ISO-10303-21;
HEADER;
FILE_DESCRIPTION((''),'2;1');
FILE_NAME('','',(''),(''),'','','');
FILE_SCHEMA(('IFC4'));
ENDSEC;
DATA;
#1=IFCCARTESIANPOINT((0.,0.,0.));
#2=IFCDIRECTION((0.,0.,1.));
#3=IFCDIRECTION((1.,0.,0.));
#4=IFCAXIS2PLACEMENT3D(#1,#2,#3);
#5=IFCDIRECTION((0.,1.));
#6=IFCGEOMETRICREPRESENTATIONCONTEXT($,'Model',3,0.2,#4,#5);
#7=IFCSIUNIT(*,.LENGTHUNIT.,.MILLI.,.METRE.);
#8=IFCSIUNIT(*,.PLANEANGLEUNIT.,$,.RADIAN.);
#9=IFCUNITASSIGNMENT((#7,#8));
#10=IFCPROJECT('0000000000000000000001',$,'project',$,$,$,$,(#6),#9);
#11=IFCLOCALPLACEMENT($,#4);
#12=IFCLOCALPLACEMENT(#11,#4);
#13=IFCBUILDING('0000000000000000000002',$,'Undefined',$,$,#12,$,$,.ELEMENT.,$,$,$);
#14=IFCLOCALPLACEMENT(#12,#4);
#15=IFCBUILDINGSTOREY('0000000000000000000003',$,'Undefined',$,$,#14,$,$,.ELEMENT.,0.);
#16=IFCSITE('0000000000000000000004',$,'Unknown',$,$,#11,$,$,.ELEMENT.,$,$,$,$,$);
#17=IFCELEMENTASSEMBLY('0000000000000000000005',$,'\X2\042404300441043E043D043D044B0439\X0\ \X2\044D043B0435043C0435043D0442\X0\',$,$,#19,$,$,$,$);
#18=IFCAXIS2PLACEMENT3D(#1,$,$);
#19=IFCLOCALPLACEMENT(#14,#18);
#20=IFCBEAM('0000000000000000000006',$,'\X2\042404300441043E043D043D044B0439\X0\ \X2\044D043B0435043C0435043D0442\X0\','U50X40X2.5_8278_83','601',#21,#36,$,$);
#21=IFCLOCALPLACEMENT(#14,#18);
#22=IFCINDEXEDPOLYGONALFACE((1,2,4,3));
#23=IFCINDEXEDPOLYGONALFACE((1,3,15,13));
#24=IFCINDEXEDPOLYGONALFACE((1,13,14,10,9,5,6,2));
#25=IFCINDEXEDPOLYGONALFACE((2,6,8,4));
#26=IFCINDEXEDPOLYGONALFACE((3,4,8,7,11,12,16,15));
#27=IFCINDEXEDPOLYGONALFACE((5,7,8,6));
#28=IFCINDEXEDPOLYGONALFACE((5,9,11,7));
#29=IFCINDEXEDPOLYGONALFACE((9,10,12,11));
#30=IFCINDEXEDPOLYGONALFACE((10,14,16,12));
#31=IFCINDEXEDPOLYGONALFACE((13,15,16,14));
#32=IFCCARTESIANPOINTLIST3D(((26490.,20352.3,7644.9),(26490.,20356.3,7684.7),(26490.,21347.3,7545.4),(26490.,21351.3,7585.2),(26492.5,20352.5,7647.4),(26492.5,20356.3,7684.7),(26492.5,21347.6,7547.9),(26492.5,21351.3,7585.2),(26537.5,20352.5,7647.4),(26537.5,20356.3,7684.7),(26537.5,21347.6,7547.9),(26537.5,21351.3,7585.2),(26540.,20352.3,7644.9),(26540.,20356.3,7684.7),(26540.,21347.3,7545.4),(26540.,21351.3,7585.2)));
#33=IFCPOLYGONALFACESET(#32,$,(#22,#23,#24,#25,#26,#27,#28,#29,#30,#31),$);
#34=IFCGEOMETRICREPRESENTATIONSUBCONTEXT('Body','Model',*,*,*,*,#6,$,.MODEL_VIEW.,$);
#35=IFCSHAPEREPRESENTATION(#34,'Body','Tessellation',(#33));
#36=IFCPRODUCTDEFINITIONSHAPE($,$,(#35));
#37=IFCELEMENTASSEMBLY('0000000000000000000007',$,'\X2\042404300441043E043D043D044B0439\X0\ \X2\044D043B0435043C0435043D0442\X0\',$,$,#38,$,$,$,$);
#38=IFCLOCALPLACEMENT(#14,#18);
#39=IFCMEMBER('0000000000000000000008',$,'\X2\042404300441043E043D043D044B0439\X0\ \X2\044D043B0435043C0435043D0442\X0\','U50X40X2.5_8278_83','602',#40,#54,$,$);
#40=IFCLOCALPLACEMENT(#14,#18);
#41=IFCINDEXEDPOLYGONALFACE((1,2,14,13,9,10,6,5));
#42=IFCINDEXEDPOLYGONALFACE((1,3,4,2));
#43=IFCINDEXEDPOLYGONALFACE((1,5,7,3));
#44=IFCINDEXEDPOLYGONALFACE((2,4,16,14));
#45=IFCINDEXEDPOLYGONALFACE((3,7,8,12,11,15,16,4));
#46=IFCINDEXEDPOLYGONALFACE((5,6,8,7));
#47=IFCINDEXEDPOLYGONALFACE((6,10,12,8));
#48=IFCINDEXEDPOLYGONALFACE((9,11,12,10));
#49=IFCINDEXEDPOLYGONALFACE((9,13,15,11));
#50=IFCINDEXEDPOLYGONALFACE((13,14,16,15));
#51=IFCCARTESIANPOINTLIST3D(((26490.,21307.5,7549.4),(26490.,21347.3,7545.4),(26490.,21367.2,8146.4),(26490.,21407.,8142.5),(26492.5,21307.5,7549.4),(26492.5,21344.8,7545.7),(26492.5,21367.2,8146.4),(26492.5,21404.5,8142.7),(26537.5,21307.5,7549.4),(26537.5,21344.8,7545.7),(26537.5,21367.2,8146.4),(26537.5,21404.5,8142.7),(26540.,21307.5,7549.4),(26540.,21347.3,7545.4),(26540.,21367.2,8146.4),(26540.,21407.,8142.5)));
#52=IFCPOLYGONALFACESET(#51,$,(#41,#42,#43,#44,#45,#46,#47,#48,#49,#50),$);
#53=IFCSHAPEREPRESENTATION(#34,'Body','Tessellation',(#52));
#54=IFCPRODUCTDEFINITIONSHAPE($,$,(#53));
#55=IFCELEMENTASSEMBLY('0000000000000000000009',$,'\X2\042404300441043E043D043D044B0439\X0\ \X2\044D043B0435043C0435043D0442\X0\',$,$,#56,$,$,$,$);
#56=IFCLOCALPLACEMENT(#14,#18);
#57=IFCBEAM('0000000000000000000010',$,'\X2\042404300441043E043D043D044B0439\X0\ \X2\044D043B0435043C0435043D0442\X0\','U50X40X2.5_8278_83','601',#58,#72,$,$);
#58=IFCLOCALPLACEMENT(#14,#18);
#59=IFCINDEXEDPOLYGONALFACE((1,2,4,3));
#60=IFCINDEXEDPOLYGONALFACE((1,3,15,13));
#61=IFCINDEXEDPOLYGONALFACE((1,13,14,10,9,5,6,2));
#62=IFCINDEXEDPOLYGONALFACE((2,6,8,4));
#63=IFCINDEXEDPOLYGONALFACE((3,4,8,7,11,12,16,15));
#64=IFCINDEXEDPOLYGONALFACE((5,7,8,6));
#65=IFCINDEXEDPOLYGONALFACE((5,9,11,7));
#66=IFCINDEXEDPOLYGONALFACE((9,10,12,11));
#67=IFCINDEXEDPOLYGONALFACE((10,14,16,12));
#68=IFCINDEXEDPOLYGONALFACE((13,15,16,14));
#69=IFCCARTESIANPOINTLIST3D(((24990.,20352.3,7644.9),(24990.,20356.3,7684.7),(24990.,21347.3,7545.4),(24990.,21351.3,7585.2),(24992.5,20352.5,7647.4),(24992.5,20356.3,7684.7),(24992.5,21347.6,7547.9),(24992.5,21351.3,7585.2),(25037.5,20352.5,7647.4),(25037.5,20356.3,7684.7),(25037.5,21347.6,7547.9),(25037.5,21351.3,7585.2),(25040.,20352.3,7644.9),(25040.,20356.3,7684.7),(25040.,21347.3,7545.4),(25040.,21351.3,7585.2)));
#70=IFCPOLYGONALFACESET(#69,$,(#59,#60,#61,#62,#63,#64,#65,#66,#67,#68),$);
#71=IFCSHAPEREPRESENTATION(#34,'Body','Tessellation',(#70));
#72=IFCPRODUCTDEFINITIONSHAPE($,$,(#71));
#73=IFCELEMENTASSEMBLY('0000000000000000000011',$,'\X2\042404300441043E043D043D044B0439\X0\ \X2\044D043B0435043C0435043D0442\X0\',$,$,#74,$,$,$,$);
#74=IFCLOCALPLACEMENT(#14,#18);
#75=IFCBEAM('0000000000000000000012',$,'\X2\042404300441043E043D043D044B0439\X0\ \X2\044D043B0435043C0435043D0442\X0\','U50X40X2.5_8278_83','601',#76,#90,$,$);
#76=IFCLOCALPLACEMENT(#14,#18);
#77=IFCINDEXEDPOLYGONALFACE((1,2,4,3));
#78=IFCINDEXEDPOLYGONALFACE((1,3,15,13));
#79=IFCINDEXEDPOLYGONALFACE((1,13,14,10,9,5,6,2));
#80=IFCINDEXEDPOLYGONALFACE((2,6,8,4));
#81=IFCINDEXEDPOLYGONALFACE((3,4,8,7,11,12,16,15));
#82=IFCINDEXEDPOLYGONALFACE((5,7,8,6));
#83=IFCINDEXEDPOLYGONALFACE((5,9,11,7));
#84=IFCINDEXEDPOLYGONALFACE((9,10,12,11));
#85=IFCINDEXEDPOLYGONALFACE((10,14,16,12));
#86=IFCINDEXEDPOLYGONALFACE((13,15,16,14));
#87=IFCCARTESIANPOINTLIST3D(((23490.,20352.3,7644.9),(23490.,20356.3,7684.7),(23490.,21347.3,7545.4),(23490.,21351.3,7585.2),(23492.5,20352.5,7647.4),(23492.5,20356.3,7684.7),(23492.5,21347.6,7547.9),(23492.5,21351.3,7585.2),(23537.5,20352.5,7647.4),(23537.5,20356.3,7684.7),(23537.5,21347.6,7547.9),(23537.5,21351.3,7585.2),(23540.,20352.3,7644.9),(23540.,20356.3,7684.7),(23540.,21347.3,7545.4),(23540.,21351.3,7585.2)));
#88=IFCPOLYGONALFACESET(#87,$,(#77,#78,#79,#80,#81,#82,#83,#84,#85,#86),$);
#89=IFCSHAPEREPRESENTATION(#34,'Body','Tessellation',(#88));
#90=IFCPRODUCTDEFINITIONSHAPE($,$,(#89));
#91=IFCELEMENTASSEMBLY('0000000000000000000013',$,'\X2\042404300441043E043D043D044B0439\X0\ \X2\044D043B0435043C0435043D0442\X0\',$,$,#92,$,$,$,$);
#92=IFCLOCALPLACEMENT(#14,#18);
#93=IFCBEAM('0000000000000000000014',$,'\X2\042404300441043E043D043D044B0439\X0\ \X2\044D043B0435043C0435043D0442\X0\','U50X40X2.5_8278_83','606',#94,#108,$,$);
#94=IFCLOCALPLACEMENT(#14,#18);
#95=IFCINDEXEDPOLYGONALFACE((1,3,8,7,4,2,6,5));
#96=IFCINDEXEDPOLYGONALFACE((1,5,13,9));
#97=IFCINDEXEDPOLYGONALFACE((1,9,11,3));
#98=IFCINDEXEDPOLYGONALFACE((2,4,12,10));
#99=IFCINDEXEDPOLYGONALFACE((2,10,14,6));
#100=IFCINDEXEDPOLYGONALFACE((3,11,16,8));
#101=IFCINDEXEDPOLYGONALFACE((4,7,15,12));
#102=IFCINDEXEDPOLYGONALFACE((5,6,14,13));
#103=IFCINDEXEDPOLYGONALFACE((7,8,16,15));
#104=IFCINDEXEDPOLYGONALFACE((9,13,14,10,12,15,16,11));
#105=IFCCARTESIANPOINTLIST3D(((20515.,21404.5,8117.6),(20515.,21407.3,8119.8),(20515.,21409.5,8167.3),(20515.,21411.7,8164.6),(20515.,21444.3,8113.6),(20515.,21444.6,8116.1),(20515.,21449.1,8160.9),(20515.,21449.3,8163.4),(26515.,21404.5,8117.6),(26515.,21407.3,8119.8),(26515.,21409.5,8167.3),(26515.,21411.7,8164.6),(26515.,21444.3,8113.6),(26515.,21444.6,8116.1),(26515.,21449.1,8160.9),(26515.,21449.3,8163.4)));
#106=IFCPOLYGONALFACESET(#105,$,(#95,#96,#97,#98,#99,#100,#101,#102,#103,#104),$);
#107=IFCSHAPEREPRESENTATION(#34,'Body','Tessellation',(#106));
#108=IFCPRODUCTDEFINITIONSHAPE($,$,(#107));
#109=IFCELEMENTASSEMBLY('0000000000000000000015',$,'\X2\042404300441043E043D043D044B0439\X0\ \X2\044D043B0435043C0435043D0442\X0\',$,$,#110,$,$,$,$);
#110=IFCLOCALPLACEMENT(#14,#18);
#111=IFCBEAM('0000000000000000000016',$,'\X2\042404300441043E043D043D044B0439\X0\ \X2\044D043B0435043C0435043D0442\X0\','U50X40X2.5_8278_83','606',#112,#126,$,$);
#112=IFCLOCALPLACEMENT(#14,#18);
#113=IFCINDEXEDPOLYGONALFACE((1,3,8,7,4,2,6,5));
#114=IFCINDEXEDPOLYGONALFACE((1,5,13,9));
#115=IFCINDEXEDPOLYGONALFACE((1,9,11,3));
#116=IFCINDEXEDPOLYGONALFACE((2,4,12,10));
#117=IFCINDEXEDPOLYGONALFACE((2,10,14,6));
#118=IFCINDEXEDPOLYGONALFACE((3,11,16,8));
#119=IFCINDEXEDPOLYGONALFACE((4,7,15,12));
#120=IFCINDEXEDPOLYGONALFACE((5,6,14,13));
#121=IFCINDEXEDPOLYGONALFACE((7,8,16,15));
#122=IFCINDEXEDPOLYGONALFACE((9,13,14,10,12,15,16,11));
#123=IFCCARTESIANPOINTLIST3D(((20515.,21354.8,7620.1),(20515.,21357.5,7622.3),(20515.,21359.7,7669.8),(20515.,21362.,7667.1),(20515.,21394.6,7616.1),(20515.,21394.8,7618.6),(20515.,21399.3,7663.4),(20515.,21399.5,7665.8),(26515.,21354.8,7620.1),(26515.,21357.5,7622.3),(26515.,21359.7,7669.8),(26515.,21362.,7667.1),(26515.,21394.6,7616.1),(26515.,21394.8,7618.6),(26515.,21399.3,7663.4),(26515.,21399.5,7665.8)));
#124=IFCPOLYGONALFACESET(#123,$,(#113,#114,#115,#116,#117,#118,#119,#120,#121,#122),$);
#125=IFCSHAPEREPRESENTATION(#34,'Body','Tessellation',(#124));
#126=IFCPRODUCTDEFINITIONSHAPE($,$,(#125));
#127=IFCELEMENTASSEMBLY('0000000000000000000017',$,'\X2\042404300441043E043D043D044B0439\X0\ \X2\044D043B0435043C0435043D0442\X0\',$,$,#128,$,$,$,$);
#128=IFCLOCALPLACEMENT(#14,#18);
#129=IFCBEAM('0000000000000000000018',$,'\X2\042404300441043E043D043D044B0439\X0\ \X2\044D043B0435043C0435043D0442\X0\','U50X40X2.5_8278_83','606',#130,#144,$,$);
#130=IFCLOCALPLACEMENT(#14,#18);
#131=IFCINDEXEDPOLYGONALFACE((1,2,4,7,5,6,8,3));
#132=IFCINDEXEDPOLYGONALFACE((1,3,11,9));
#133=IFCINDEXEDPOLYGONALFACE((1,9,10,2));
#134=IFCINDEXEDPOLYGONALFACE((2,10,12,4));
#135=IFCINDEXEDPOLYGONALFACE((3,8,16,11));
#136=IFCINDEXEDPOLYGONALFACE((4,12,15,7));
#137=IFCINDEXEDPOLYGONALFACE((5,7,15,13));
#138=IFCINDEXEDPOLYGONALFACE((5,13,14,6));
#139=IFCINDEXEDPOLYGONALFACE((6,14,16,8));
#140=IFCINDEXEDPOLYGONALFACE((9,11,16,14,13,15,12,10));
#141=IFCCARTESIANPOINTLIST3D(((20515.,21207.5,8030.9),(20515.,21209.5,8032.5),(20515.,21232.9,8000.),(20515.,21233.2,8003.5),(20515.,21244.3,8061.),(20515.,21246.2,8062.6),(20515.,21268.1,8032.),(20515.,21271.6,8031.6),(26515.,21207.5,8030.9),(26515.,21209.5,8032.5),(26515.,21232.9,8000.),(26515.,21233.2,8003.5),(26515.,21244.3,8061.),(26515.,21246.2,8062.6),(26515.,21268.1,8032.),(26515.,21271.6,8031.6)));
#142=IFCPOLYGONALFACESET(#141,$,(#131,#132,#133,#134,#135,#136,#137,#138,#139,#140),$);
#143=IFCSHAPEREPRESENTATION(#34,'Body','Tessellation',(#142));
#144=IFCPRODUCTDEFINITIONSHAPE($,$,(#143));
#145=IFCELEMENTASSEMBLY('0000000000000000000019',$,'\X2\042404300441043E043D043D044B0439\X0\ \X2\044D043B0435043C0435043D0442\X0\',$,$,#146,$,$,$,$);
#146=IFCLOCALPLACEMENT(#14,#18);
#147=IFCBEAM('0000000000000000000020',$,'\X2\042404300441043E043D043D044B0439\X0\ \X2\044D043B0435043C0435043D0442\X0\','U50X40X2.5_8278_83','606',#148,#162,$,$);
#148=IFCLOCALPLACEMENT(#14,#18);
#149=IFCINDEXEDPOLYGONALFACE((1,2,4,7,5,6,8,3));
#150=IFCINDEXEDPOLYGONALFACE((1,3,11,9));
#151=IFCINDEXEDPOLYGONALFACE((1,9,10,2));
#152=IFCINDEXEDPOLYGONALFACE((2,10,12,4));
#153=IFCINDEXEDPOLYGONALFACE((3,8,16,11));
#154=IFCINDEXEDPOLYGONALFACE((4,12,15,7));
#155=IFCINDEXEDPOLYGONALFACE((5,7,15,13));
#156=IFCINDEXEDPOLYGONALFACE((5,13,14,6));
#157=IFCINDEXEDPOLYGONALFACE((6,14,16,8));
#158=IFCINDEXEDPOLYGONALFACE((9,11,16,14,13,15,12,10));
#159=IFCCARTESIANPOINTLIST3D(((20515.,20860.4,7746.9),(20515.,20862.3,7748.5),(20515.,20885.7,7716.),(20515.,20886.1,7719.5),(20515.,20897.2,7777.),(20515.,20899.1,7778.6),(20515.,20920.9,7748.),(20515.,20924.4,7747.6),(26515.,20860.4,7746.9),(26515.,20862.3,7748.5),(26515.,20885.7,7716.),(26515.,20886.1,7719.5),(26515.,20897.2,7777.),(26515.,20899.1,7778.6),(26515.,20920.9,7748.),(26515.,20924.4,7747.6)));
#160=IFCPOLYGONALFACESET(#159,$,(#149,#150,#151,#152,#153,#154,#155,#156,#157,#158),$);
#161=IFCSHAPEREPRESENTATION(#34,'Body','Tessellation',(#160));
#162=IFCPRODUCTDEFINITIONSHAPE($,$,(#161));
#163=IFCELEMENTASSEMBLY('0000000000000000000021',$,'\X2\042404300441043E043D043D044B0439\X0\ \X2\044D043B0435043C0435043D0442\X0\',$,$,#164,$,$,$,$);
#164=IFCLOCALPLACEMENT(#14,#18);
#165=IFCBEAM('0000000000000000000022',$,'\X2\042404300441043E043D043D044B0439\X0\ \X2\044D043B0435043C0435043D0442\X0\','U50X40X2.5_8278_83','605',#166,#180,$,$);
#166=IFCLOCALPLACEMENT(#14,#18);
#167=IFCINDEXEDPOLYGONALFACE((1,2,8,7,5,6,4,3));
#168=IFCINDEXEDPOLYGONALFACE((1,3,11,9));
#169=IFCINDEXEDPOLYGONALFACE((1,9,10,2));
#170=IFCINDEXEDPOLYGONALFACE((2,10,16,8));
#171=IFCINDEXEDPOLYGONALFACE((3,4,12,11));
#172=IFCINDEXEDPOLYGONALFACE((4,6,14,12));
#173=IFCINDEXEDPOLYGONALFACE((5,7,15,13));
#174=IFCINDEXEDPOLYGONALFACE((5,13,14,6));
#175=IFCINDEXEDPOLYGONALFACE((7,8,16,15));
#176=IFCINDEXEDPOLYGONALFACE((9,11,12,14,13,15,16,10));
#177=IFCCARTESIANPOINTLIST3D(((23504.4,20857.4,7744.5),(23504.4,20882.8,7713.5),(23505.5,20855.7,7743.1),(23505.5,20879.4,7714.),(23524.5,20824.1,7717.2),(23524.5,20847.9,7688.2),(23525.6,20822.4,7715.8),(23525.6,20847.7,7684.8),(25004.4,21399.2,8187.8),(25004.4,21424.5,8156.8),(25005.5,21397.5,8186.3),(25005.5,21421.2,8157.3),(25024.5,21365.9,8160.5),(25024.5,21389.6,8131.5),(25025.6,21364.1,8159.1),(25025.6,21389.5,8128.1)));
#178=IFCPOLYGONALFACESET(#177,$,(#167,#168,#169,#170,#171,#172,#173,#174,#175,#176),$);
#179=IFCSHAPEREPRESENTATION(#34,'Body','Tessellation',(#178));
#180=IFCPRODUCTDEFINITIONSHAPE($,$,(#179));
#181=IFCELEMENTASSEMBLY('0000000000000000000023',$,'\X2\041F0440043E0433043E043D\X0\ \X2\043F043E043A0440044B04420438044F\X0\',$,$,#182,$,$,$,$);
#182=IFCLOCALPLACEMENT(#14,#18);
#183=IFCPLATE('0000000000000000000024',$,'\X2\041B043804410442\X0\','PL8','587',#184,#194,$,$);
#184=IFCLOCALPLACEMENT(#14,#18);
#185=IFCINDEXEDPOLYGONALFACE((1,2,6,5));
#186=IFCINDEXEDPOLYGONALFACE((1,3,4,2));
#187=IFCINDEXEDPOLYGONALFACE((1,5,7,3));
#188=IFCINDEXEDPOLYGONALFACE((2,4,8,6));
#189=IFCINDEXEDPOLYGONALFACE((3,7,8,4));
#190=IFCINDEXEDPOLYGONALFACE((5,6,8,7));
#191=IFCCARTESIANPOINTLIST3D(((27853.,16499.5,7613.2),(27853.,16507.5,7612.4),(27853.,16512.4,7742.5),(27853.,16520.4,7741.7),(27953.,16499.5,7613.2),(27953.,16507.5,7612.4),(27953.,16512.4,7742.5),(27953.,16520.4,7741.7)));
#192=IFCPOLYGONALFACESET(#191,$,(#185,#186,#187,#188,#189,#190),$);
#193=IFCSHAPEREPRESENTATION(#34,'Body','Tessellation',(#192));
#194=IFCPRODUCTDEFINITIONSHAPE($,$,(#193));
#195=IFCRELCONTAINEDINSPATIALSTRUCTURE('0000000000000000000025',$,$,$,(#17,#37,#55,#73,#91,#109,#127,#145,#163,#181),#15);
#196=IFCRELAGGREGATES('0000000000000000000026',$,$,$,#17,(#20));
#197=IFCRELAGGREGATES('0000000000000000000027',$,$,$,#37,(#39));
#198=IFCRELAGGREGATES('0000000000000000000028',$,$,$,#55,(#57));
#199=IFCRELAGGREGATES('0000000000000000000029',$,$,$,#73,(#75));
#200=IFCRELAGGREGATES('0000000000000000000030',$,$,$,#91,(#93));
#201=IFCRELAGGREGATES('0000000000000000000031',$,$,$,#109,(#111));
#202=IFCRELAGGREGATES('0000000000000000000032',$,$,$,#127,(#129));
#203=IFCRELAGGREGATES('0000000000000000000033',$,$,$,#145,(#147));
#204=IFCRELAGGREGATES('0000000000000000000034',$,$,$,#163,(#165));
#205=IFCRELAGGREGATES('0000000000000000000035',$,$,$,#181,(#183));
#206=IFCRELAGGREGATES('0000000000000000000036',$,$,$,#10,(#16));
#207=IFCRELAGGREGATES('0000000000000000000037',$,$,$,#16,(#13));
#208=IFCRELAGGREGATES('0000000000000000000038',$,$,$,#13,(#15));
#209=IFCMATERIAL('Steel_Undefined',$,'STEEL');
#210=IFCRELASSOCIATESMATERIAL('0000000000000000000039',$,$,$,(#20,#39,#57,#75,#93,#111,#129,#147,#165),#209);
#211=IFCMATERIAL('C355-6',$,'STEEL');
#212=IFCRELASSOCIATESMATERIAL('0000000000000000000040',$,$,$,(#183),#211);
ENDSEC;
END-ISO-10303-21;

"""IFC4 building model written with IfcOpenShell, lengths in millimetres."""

from ifc_helpers import new_model, si_unit, direction, frame, origin_with_axes, place, context, subcontext, project, spatial, line, indexed_curve, outline, extrude, material, element, aggregate, save


model = new_model("IFC4")

# Units and contexts
model_context = context("Model", 3, precision=0.2, world=origin_with_axes(), true_north=direction((0.0, 1.0)))
body_context = subcontext(model_context, "Body", "Model", "MODEL_VIEW")
ifc_project = project(units=[si_unit("LENGTHUNIT", "METRE", prefix="MILLI"), si_unit("PLANEANGLEUNIT", "RADIAN")], contexts=[model_context])

# Site, building, storey
site_placement = place(None, origin_with_axes())
site = spatial("IfcSite", under=ifc_project, at=site_placement, Name="Unknown", CompositionType="ELEMENT")
building_placement = place(site_placement, origin_with_axes())
building = spatial("IfcBuilding", under=site, at=building_placement, Name="Undefined", CompositionType="ELEMENT")
storey_placement = place(building_placement, origin_with_axes())
storey = spatial("IfcBuildingStorey", under=building, at=storey_placement, Name="Undefined", CompositionType="ELEMENT", Elevation=0.0)

# Element assembly, beam
assembly_1_placement = place(storey_placement, frame((26515.0, 21349.3, 7565.3), z_axis=(0.0, 0.099504, 0.995037), x_axis=(0.0, -0.995037, 0.099504)))
assembly_1 = element("IfcElementAssembly", 1, at=assembly_1_placement, inside=storey, Name="Фасонный элемент")
ifc_material_1 = material(Name="Steel_Undefined", Category="STEEL")
beam_1_placement = place(assembly_1_placement, origin_with_axes())
beam_1 = element("IfcBeam", 2, at=beam_1_placement, material=ifc_material_1, Name="Фасонный элемент", Description="U50X40X2.5_8278_83", ObjectType="601", context=body_context, shape_type="SolidModel", body=[
    extrude(outline(indexed_curve([(-20.0, -25.0), (20.0, -25.0), (20.0, -22.5), (-17.5, -22.5), (-17.5, 22.5), (20.0, 22.5), (20.0, 25.0), (-20.0, 25.0)], segments=[line(1, 2, 3, 4, 5, 6, 7, 8, 1)])), frame((0.0, 0.0, 0.0), z_axis=(-1.0, 0.0, 0.0), x_axis=(0.0, 0.0, 1.0)), (0.0, 0.0, -1.0), 1000.0),
])
aggregate(assembly_1, [beam_1])

# Element assembly, member
assembly_2_placement = place(storey_placement, frame((26515.0, 21327.4, 7547.4), z_axis=(0.0, -0.995037, 0.099504), x_axis=(0.0, 0.099504, 0.995037)))
assembly_2 = element("IfcElementAssembly", 3, at=assembly_2_placement, inside=storey, Name="Фасонный элемент")
member_placement = place(assembly_2_placement, origin_with_axes())
member = element("IfcMember", 4, at=member_placement, material=ifc_material_1, Name="Фасонный элемент", Description="U50X40X2.5_8278_83", ObjectType="602", context=body_context, shape_type="SolidModel", body=[
    extrude(outline(indexed_curve([(-20.0, -25.0), (20.0, -25.0), (20.0, -22.5), (-17.5, -22.5), (-17.5, 22.5), (20.0, 22.5), (20.0, 25.0), (-20.0, 25.0)], segments=[line(1, 2, 3, 4, 5, 6, 7, 8, 1)])), frame((0.0, 0.0, 0.0), z_axis=(-1.0, 0.0, 0.0), x_axis=(0.0, 0.0, 1.0)), (0.0, 0.0, -1.0), 600.0),
])
aggregate(assembly_2, [member])

# Element assemblies, beams
assembly_3_placement = place(storey_placement, frame((25015.0, 21349.3, 7565.3), z_axis=(0.0, 0.099504, 0.995037), x_axis=(0.0, -0.995037, 0.099504)))
assembly_3 = element("IfcElementAssembly", 5, at=assembly_3_placement, inside=storey, Name="Фасонный элемент")
beam_2_placement = place(assembly_3_placement, origin_with_axes())
beam_2 = element("IfcBeam", 6, at=beam_2_placement, material=ifc_material_1, Name="Фасонный элемент", Description="U50X40X2.5_8278_83", ObjectType="601", context=body_context, shape_type="SolidModel", body=[
    extrude(outline(indexed_curve([(-20.0, -25.0), (20.0, -25.0), (20.0, -22.5), (-17.5, -22.5), (-17.5, 22.5), (20.0, 22.5), (20.0, 25.0), (-20.0, 25.0)], segments=[line(1, 2, 3, 4, 5, 6, 7, 8, 1)])), frame((0.0, 0.0, 0.0), z_axis=(-1.0, 0.0, 0.0), x_axis=(0.0, 0.0, 1.0)), (0.0, 0.0, -1.0), 1000.0),
])
aggregate(assembly_3, [beam_2])
assembly_4_placement = place(storey_placement, frame((23515.0, 21349.3, 7565.3), z_axis=(0.0, 0.099504, 0.995037), x_axis=(0.0, -0.995037, 0.099504)))
assembly_4 = element("IfcElementAssembly", 7, at=assembly_4_placement, inside=storey, Name="Фасонный элемент")
beam_3_placement = place(assembly_4_placement, origin_with_axes())
beam_3 = element("IfcBeam", 8, at=beam_3_placement, material=ifc_material_1, Name="Фасонный элемент", Description="U50X40X2.5_8278_83", ObjectType="601", context=body_context, shape_type="SolidModel", body=[
    extrude(outline(indexed_curve([(-20.0, -25.0), (20.0, -25.0), (20.0, -22.5), (-17.5, -22.5), (-17.5, 22.5), (20.0, 22.5), (20.0, 25.0), (-20.0, 25.0)], segments=[line(1, 2, 3, 4, 5, 6, 7, 8, 1)])), frame((0.0, 0.0, 0.0), z_axis=(-1.0, 0.0, 0.0), x_axis=(0.0, 0.0, 1.0)), (0.0, 0.0, -1.0), 1000.0),
])
aggregate(assembly_4, [beam_3])
assembly_5_placement = place(storey_placement, frame((26515.0, 21426.9, 8140.5), z_axis=(0.0, 0.995037, -0.099504), x_axis=(-1.0, 0.0, 0.0)))
assembly_5 = element("IfcElementAssembly", 9, at=assembly_5_placement, inside=storey, Name="Фасонный элемент")
beam_4_placement = place(assembly_5_placement, origin_with_axes())
beam_4 = element("IfcBeam", 10, at=beam_4_placement, material=ifc_material_1, Name="Фасонный элемент", Description="U50X40X2.5_8278_83", ObjectType="606", context=body_context, shape_type="SolidModel", body=[
    extrude(outline(indexed_curve([(-20.0, -25.0), (20.0, -25.0), (20.0, -22.5), (-17.5, -22.5), (-17.5, 22.5), (20.0, 22.5), (20.0, 25.0), (-20.0, 25.0)], segments=[line(1, 2, 3, 4, 5, 6, 7, 8, 1)])), frame((0.0, 0.0, 0.0), z_axis=(-1.0, 0.0, 0.0), x_axis=(0.0, 0.0, 1.0)), (0.0, 0.0, -1.0), 6000.0),
])
aggregate(assembly_5, [beam_4])
assembly_6_placement = place(storey_placement, frame((26515.0, 21377.2, 7643.0), z_axis=(0.0, 0.995037, -0.099504), x_axis=(-1.0, 0.0, 0.0)))
assembly_6 = element("IfcElementAssembly", 11, at=assembly_6_placement, inside=storey, Name="Фасонный элемент")
beam_5_placement = place(assembly_6_placement, origin_with_axes())
beam_5 = element("IfcBeam", 12, at=beam_5_placement, material=ifc_material_1, Name="Фасонный элемент", Description="U50X40X2.5_8278_83", ObjectType="606", context=body_context, shape_type="SolidModel", body=[
    extrude(outline(indexed_curve([(-20.0, -25.0), (20.0, -25.0), (20.0, -22.5), (-17.5, -22.5), (-17.5, 22.5), (20.0, 22.5), (20.0, 25.0), (-20.0, 25.0)], segments=[line(1, 2, 3, 4, 5, 6, 7, 8, 1)])), frame((0.0, 0.0, 0.0), z_axis=(-1.0, 0.0, 0.0), x_axis=(0.0, 0.0, 1.0)), (0.0, 0.0, -1.0), 6000.0),
])
aggregate(assembly_6, [beam_5])
assembly_7_placement = place(storey_placement, frame((26515.0, 21239.6, 8031.3), z_axis=(0.0, -0.633238, 0.773957), x_axis=(-1.0, 0.0, 0.0)))
assembly_7 = element("IfcElementAssembly", 13, at=assembly_7_placement, inside=storey, Name="Фасонный элемент")
beam_6_placement = place(assembly_7_placement, origin_with_axes())
beam_6 = element("IfcBeam", 14, at=beam_6_placement, material=ifc_material_1, Name="Фасонный элемент", Description="U50X40X2.5_8278_83", ObjectType="606", context=body_context, shape_type="SolidModel", body=[
    extrude(outline(indexed_curve([(-20.0, -25.0), (20.0, -25.0), (20.0, -22.5), (-17.5, -22.5), (-17.5, 22.5), (20.0, 22.5), (20.0, 25.0), (-20.0, 25.0)], segments=[line(1, 2, 3, 4, 5, 6, 7, 8, 1)])), frame((0.0, 0.0, 0.0), z_axis=(-1.0, 0.0, 0.0), x_axis=(0.0, 0.0, 1.0)), (0.0, 0.0, -1.0), 6000.0),
])
aggregate(assembly_7, [beam_6])
assembly_8_placement = place(storey_placement, frame((26515.0, 20892.4, 7747.3), z_axis=(0.0, -0.633238, 0.773957), x_axis=(-1.0, 0.0, 0.0)))
assembly_8 = element("IfcElementAssembly", 15, at=assembly_8_placement, inside=storey, Name="Фасонный элемент")
beam_7_placement = place(assembly_8_placement, origin_with_axes())
beam_7 = element("IfcBeam", 16, at=beam_7_placement, material=ifc_material_1, Name="Фасонный элемент", Description="U50X40X2.5_8278_83", ObjectType="606", context=body_context, shape_type="SolidModel", body=[
    extrude(outline(indexed_curve([(-20.0, -25.0), (20.0, -25.0), (20.0, -22.5), (-17.5, -22.5), (-17.5, 22.5), (20.0, 22.5), (20.0, 25.0), (-20.0, 25.0)], segments=[line(1, 2, 3, 4, 5, 6, 7, 8, 1)])), frame((0.0, 0.0, 0.0), z_axis=(-1.0, 0.0, 0.0), x_axis=(0.0, 0.0, 1.0)), (0.0, 0.0, -1.0), 6000.0),
])
aggregate(assembly_8, [beam_7])
assembly_9_placement = place(storey_placement, frame((25015.0, 21394.3, 8157.9), z_axis=(0.0, -0.633238, 0.773957), x_axis=(-0.906183, -0.327295, -0.267787)))
assembly_9 = element("IfcElementAssembly", 17, at=assembly_9_placement, inside=storey, Name="Фасонный элемент")
beam_8_placement = place(assembly_9_placement, origin_with_axes())
beam_8 = element("IfcBeam", 18, at=beam_8_placement, material=ifc_material_1, Name="Фасонный элемент", Description="U50X40X2.5_8278_83", ObjectType="605", context=body_context, shape_type="SolidModel", body=[
    extrude(outline(indexed_curve([(-20.0, -25.0), (20.0, -25.0), (20.0, -22.5), (-17.5, -22.5), (-17.5, 22.5), (20.0, 22.5), (20.0, 25.0), (-20.0, 25.0)], segments=[line(1, 2, 3, 4, 5, 6, 7, 8, 1)])), frame((0.0, 0.0, 0.0), z_axis=(-1.0, 0.0, 0.0), x_axis=(0.0, 0.0, 1.0)), (0.0, 0.0, -1.0), 1655.3),
])
aggregate(assembly_9, [beam_8])

# Element assembly, plate
ifc_material_2 = material(Name="C355-6", Category="STEEL")
assembly_10_placement = place(storey_placement, frame((28000.0, 16510.0, 7677.5), z_axis=(0.0, -0.995037, 0.099504), x_axis=(-1.0, 0.0, 0.0)))
assembly_10 = element("IfcElementAssembly", 19, at=assembly_10_placement, inside=storey, Name="Прогон покрытия")
plate_1_placement = place(assembly_10_placement, frame((47.0, -65.0, 0.0), z_axis=(0.0, 0.0, 1.0), x_axis=(1.0, 0.0, 0.0)))
plate_1 = element("IfcPlate", 20, at=plate_1_placement, material=ifc_material_2, Name="Лист", Description="PL8", ObjectType="587", context=body_context, shape_type="SolidModel", body=[
    extrude(outline(indexed_curve([(0.0, 0.0), (100.0, 0.0), (100.0, 130.0), (0.0, 130.0)], segments=[line(1, 2, 3, 4, 1)])), frame((0.0, 0.0, 4.0), z_axis=(0.0, 0.0, 1.0), x_axis=(1.0, 0.0, 0.0)), (0.0, 0.0, -1.0), 8.0),
])
aggregate(assembly_10, [plate_1])

save(model, "model.ifc")
